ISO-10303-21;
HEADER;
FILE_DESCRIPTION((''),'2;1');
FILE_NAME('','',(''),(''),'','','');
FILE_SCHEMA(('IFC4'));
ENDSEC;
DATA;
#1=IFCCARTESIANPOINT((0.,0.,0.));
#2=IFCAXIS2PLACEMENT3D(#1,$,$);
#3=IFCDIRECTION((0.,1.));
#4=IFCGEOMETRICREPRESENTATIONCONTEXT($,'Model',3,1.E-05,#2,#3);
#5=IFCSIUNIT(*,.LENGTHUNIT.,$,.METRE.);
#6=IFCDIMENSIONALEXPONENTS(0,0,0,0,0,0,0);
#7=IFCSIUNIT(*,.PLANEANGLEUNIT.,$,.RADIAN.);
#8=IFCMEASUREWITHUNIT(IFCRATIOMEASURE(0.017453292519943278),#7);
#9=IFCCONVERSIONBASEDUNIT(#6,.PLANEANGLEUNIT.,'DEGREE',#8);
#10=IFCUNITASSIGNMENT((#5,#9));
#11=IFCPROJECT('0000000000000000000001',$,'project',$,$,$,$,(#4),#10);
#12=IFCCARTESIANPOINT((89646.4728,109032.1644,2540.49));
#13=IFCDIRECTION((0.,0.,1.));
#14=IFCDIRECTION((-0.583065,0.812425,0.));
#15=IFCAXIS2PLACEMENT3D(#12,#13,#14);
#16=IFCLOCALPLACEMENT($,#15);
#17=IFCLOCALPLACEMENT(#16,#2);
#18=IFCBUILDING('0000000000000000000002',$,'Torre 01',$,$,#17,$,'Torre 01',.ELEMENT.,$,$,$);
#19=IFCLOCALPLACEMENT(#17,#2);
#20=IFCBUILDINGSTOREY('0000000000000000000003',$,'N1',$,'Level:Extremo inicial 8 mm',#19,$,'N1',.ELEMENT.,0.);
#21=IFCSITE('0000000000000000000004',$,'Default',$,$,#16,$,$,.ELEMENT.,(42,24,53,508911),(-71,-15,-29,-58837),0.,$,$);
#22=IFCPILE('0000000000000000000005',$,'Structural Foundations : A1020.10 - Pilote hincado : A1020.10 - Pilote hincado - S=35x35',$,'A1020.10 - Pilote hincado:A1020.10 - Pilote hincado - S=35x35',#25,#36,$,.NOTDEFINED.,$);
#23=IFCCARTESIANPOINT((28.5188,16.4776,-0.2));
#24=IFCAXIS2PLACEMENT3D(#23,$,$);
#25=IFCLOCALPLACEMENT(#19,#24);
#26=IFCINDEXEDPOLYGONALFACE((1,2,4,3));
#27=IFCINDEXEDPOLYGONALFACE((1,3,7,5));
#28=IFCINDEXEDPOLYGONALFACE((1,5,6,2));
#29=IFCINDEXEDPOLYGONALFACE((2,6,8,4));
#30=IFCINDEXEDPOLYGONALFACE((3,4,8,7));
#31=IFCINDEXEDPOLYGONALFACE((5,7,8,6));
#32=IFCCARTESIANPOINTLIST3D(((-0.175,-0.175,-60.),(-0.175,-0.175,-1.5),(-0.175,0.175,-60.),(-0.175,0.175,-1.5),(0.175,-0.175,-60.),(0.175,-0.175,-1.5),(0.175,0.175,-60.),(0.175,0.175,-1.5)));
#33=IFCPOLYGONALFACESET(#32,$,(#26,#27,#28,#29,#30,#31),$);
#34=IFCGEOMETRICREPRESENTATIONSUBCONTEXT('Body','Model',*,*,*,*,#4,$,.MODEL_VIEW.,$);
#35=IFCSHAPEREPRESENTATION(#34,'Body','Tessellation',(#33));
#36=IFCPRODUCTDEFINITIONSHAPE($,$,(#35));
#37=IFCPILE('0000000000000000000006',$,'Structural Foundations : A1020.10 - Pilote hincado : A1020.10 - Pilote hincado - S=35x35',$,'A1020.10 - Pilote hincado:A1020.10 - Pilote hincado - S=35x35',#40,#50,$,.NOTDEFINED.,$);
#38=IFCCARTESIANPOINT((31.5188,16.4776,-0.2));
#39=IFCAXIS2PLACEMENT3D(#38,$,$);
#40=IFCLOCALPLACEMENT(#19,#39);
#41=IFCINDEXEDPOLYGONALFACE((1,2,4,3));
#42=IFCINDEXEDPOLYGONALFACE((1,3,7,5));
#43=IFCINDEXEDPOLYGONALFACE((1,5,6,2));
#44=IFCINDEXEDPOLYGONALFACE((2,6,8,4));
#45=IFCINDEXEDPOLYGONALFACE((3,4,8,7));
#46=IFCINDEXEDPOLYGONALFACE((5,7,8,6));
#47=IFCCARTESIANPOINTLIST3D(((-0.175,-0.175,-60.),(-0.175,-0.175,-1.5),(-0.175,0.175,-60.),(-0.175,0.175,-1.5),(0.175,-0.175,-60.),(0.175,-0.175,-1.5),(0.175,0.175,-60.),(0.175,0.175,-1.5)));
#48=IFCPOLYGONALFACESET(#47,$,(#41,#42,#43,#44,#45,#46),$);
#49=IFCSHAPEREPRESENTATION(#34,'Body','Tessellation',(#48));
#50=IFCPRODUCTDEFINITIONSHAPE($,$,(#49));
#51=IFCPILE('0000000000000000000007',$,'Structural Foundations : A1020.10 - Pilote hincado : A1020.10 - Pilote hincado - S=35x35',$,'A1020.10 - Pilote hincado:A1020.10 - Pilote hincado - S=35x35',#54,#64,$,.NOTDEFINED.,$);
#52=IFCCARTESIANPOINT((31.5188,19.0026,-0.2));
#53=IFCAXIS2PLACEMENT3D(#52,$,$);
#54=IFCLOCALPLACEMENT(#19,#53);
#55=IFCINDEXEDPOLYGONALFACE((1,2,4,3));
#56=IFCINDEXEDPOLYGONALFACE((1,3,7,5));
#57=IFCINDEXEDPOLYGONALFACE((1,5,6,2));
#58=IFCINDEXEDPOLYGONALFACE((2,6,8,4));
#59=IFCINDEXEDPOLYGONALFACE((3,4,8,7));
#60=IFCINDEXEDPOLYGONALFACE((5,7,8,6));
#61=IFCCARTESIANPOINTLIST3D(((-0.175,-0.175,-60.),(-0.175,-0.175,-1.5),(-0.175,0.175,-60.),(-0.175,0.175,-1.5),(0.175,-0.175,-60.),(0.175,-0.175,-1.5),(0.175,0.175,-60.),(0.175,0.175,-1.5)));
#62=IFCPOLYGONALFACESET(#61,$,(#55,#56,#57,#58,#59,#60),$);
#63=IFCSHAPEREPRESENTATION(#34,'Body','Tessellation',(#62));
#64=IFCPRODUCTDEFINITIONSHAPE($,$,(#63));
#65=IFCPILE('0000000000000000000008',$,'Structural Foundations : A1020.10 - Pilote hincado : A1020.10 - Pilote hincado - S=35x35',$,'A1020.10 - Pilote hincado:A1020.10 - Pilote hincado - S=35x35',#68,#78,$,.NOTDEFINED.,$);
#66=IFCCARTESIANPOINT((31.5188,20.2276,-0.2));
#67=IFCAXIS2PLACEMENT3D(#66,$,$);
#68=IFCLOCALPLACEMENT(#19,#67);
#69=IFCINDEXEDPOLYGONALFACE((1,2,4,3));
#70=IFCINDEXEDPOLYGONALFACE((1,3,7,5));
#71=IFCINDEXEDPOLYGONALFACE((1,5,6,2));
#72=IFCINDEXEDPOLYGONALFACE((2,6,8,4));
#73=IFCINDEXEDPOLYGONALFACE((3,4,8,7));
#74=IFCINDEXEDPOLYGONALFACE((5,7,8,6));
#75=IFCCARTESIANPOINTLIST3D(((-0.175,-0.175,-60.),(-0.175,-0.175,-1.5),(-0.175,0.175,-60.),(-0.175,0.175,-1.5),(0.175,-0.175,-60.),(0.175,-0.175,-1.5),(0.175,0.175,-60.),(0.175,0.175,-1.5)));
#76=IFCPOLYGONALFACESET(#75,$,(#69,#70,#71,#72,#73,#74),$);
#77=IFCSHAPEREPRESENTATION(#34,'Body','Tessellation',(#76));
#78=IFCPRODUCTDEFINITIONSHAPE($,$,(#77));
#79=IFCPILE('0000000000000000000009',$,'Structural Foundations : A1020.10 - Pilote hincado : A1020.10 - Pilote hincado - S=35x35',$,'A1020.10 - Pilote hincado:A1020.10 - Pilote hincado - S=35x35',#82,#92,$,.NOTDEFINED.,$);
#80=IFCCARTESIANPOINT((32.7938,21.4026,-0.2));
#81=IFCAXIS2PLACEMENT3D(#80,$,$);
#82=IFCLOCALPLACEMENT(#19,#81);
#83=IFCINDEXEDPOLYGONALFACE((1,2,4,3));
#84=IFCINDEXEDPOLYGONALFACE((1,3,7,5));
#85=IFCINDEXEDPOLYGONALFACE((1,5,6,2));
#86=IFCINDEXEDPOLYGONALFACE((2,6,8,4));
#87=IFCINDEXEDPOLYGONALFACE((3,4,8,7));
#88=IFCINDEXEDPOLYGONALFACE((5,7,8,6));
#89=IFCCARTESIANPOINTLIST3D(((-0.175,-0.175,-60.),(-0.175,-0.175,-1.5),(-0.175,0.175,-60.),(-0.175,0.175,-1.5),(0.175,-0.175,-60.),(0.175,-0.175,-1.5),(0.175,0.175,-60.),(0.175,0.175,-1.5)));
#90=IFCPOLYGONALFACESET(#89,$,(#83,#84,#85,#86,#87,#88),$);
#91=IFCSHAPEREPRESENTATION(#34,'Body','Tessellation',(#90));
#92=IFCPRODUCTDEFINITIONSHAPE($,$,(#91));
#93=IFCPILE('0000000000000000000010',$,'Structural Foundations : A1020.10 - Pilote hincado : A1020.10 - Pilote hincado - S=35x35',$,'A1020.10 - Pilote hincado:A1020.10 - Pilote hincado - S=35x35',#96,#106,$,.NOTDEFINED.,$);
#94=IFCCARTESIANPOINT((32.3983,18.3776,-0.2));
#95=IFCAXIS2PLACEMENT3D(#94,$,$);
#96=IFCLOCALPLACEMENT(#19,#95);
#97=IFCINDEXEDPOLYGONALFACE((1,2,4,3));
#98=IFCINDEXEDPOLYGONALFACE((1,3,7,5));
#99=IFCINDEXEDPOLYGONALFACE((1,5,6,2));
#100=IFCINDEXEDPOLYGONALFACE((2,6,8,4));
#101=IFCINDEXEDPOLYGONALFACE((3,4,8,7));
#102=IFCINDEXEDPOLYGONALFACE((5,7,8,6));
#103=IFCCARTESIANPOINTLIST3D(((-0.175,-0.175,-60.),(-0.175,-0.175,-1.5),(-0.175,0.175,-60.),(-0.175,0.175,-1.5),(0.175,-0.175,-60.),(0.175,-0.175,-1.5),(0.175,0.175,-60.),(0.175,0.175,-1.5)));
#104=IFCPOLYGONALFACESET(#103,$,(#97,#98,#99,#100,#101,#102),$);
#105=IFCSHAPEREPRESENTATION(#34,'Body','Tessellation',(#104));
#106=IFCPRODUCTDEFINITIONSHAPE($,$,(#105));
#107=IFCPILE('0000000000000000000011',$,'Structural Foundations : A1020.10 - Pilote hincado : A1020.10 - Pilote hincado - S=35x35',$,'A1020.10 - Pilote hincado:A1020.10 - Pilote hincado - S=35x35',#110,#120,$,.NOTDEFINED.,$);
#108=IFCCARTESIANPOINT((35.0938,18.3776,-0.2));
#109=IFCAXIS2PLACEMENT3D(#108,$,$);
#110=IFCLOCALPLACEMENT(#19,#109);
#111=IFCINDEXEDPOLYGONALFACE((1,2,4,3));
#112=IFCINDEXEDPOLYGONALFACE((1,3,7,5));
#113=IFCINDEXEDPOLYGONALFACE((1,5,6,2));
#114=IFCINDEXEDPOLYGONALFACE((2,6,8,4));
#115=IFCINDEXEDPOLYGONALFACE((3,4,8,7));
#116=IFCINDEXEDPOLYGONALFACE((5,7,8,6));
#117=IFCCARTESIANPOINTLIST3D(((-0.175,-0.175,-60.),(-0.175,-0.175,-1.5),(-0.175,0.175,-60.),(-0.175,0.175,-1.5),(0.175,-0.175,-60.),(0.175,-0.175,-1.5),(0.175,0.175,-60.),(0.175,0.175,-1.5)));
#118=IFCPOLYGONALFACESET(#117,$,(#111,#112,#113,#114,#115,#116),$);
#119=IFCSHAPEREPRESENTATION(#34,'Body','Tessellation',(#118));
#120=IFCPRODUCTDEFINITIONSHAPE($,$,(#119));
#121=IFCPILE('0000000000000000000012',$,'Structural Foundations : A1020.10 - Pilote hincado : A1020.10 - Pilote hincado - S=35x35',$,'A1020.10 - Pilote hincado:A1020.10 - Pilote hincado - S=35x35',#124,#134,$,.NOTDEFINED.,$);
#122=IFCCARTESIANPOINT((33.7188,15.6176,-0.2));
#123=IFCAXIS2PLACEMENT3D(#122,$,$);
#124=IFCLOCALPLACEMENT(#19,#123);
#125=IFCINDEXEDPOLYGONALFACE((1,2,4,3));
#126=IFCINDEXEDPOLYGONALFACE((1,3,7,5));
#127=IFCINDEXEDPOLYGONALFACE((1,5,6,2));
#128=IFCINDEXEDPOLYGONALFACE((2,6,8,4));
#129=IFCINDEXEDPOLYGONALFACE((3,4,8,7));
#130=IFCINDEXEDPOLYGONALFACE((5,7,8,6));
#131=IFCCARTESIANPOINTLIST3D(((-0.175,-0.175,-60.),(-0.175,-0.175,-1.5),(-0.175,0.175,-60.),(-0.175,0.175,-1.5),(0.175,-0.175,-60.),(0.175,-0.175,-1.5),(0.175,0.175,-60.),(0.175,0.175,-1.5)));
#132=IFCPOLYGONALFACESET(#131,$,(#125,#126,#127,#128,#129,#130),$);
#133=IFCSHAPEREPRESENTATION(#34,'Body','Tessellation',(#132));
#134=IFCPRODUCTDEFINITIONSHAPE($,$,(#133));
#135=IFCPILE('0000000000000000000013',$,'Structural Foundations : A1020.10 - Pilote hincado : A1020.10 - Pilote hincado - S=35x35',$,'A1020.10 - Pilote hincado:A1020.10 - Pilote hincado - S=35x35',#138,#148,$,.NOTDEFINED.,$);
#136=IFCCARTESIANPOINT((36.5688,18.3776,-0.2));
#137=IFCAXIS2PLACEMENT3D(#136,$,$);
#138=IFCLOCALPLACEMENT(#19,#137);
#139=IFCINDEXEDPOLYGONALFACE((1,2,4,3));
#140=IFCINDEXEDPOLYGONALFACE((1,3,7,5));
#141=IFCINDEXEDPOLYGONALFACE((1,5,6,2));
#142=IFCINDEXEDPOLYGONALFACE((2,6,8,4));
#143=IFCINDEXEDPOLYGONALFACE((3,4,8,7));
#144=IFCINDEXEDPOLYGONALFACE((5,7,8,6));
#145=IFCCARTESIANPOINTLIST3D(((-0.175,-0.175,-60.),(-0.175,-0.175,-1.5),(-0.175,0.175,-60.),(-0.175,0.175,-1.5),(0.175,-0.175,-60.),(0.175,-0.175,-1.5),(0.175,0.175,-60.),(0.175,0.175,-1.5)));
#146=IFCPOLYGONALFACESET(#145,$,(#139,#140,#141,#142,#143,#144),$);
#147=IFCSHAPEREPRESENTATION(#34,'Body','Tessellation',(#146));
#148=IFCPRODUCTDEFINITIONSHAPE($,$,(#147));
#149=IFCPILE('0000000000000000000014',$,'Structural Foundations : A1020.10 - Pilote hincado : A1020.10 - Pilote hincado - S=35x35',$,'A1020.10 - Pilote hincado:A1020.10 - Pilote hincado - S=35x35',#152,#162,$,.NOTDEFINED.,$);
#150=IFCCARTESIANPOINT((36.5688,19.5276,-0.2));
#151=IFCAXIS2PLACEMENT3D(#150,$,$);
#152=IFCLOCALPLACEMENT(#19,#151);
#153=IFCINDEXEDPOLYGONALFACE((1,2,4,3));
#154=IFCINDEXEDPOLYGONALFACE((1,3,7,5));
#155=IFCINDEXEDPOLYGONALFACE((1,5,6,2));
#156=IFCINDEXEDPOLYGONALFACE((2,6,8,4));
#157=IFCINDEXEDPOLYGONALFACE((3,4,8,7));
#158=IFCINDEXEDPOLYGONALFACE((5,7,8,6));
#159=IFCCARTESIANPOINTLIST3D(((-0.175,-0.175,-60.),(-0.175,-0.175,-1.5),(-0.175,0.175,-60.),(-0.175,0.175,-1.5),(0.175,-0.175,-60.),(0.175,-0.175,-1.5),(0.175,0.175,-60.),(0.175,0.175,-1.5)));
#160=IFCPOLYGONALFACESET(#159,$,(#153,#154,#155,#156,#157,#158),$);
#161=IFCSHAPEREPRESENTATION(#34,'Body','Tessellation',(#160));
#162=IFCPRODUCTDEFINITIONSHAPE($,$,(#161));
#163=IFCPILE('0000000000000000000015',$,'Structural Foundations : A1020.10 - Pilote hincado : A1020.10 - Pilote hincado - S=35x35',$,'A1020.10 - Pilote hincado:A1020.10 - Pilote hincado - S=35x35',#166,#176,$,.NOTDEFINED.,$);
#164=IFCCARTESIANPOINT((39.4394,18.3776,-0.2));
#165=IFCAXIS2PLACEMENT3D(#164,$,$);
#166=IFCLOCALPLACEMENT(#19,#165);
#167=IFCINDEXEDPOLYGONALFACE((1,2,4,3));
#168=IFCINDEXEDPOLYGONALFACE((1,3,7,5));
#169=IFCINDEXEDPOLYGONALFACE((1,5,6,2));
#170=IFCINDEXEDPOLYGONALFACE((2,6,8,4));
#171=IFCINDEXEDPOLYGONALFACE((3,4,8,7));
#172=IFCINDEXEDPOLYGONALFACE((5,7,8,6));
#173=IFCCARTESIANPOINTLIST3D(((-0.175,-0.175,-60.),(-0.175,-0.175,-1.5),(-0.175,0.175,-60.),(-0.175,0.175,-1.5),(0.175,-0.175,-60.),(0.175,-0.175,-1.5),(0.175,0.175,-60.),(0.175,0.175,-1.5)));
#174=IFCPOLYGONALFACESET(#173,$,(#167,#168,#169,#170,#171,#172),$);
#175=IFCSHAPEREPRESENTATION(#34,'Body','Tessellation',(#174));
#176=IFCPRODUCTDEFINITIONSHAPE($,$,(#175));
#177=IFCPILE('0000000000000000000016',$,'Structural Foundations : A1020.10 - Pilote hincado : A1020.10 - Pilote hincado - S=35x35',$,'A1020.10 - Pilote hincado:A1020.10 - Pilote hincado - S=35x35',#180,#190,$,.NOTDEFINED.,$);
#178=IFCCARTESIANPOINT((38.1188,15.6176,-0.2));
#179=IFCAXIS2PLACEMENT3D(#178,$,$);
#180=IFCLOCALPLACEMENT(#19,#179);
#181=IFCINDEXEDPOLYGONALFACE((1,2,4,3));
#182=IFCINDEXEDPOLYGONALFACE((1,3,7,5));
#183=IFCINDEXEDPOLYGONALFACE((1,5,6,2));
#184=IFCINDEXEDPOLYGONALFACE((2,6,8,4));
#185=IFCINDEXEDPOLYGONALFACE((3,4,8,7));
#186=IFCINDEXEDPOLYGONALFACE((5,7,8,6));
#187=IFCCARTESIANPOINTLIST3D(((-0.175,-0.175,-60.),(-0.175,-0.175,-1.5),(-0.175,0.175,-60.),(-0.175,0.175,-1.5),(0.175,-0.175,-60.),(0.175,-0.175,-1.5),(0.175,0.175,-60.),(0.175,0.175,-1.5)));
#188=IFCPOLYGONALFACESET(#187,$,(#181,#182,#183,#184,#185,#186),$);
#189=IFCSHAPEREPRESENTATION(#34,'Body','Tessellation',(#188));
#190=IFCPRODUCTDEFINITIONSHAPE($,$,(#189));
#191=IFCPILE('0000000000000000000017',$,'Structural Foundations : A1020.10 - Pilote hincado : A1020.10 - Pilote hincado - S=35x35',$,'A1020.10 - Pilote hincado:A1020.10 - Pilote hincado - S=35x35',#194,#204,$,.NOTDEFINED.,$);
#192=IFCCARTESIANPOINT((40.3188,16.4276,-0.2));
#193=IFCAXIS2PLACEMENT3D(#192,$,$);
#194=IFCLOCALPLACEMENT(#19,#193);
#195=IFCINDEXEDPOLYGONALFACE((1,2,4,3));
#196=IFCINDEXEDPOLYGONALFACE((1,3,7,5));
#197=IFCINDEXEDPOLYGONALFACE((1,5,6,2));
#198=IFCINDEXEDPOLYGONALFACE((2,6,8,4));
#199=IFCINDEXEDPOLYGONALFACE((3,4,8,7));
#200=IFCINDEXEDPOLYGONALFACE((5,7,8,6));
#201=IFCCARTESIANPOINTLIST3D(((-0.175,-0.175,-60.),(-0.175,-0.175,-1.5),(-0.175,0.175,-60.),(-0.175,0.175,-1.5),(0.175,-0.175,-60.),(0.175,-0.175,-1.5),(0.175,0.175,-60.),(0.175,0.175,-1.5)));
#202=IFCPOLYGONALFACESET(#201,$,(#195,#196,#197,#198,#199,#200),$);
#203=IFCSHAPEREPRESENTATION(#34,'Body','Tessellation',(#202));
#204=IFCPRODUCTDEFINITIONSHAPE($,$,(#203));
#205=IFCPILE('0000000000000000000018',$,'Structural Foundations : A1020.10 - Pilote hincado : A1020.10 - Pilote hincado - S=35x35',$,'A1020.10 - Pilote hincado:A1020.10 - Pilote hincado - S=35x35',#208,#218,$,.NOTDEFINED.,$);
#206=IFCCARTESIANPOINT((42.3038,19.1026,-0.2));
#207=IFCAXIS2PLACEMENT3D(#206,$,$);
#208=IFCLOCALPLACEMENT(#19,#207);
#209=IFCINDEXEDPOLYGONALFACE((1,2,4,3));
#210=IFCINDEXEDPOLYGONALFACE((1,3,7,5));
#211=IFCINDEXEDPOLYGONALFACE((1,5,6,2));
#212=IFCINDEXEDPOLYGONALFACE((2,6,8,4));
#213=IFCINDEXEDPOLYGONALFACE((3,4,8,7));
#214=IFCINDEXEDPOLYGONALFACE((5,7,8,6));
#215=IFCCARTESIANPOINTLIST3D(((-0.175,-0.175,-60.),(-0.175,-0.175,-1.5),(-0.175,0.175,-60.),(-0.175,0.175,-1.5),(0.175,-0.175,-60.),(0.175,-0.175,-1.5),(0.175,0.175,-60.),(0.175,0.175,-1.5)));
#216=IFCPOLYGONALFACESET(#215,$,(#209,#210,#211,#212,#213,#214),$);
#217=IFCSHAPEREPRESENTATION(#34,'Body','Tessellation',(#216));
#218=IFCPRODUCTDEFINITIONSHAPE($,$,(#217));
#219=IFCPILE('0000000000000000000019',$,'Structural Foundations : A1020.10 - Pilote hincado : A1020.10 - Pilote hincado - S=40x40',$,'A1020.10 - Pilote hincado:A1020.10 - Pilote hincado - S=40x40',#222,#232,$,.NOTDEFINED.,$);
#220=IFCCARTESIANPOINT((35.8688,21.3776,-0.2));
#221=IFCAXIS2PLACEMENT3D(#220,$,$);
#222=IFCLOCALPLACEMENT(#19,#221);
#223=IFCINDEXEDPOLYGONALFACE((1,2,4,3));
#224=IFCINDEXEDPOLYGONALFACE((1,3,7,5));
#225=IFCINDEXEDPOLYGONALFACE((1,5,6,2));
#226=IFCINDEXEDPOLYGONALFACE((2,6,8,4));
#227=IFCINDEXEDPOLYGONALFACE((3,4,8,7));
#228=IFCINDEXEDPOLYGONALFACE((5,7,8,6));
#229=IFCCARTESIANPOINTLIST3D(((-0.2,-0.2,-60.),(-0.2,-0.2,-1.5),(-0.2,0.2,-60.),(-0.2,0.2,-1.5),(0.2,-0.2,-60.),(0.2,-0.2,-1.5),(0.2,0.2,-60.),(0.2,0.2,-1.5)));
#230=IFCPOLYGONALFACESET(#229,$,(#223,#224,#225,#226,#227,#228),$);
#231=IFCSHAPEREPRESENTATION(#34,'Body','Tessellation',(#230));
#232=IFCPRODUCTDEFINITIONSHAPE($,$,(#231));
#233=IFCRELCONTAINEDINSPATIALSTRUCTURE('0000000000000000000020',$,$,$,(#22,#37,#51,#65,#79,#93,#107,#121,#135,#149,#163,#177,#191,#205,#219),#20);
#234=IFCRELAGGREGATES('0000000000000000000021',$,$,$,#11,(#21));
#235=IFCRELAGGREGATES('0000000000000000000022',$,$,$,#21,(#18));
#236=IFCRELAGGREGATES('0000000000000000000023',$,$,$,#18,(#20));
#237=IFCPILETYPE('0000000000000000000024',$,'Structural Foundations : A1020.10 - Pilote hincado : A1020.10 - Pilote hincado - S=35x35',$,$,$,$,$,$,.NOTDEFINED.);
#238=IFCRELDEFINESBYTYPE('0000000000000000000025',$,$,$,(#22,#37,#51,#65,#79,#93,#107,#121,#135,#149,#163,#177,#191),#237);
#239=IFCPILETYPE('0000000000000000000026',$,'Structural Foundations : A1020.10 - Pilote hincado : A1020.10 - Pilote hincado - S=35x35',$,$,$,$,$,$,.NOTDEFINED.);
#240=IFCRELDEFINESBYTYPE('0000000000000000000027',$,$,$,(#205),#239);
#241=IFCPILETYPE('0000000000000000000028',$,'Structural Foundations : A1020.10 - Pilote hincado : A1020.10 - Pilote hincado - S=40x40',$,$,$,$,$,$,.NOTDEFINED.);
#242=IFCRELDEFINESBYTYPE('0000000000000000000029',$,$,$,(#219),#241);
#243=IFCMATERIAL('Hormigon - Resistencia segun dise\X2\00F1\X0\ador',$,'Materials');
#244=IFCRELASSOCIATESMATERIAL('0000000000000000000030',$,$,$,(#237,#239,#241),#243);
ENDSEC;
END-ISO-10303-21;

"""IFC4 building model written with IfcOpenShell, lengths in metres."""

from ifc_helpers import new_model, entity, si_unit, converted_unit, direction, frame, origin, origin_2d_with_axis, place, context, subcontext, project, spatial, polyline, segment, composite_curve, rectangle, outline, extrude, source, transform, mapped, material, material_profile, profile_set, type_object, type_shapes, element, save


model = new_model("IFC4")

# Units and contexts
model_context = context("Model", 3, precision=1e-05, world=origin(), true_north=direction((0.0, 1.0)))
body_context = subcontext(model_context, "Body", "Model", "MODEL_VIEW")
ifc_project = project(units=[si_unit("LENGTHUNIT", "METRE"), converted_unit("PLANEANGLEUNIT", "DEGREE", entity("IfcRatioMeasure", 0.017453292519943278), si_unit("PLANEANGLEUNIT", "RADIAN"), dimensions=[0, 0, 0, 0, 0, 0, 0])], contexts=[model_context])

# Site, building, storey
site_placement = place(None, frame((89646.4728, 109032.1644, 2540.49), z_axis=(0.0, 0.0, 1.0), x_axis=(-0.583065, 0.812425, 0.0)))
site = spatial("IfcSite", under=ifc_project, at=site_placement, Name="Default", CompositionType="ELEMENT", RefLatitude=(42, 24, 53, 508911), RefLongitude=(-71, -15, -29, -58837), RefElevation=0.0)
building_placement = place(site_placement, origin())
building = spatial("IfcBuilding", under=site, at=building_placement, Name="Torre 01", LongName="Torre 01", CompositionType="ELEMENT")
storey_placement = place(building_placement, origin())
storey = spatial("IfcBuildingStorey", under=building, at=storey_placement, Name="N1", ObjectType="Level:Extremo inicial 8 mm", LongName="N1", CompositionType="ELEMENT", Elevation=0.0)

# Piles
ifc_material_1 = material(Name="Hormigon - Resistencia segun diseñador", Category="Materials")
ifc_material_profile_1 = material_profile(ifc_material_1, outline(composite_curve([segment(polyline([(0.175, -0.175, -60.0), (-0.175, -0.175, -60.0)]), True, "CONTINUOUS"), segment(polyline([(-0.175, -0.175, -60.0), (-0.175, 0.175, -60.0)]), True, "CONTINUOUS"), segment(polyline([(-0.175, 0.175, -60.0), (0.175, 0.175, -60.0)]), True, "CONTINUOUS"), segment(polyline([(0.175, 0.175, -60.0), (0.175, -0.175, -60.0)]), True, "CONTINUOUS")], self_intersect=False), kind="CURVE"), Name="A1020.10 - Pilote hincado - S=35x35")
ifc_profile_set_1 = profile_set([ifc_material_profile_1], Name="A1020.10 - Pilote hincado - S=35x35")
pile_type_1 = type_object("IfcPileType", Name="Structural Foundations : A1020.10 - Pilote hincado : A1020.10 - Pilote hincado - S=35x35", PredefinedType="NOTDEFINED", material=ifc_profile_set_1)
shared_shape_1 = source(origin(), body_context, "Body", "SweptSolid", [
    extrude(rectangle(XDim=0.35, YDim=0.35, at=origin_2d_with_axis()), frame((0.0, 0.0, -60.0), z_axis=(0.0, 0.0, 1.0), x_axis=(0.0, -1.0, 0.0)), (0.0, 0.0, 1.0), 58.5),
])
type_shapes(pile_type_1, [shared_shape_1])
for number, where, name in (
    (1, (28.5188, 16.4776, -0.2), "Structural Foundations : A1020.10 - Pilote hincado : A1020.10 - Pilote hincado - S=35x35"),
    (2, (31.5188, 16.4776, -0.2), "Structural Foundations : A1020.10 - Pilote hincado : A1020.10 - Pilote hincado - S=35x35"),
    (3, (31.5188, 19.0026, -0.2), "Structural Foundations : A1020.10 - Pilote hincado : A1020.10 - Pilote hincado - S=35x35"),
    (4, (31.5188, 20.2276, -0.2), "Structural Foundations : A1020.10 - Pilote hincado : A1020.10 - Pilote hincado - S=35x35"),
    (5, (32.7938, 21.4026, -0.2), "Structural Foundations : A1020.10 - Pilote hincado : A1020.10 - Pilote hincado - S=35x35"),
    (6, (32.3983, 18.3776, -0.2), "Structural Foundations : A1020.10 - Pilote hincado : A1020.10 - Pilote hincado - S=35x35"),
    (7, (35.0938, 18.3776, -0.2), "Structural Foundations : A1020.10 - Pilote hincado : A1020.10 - Pilote hincado - S=35x35"),
    (8, (33.7188, 15.6176, -0.2), "Structural Foundations : A1020.10 - Pilote hincado : A1020.10 - Pilote hincado - S=35x35"),
    (9, (36.5688, 18.3776, -0.2), "Structural Foundations : A1020.10 - Pilote hincado : A1020.10 - Pilote hincado - S=35x35"),
    (10, (36.5688, 19.5276, -0.2), "Structural Foundations : A1020.10 - Pilote hincado : A1020.10 - Pilote hincado - S=35x35"),
    (11, (39.4394, 18.3776, -0.2), "Structural Foundations : A1020.10 - Pilote hincado : A1020.10 - Pilote hincado - S=35x35"),
    (12, (38.1188, 15.6176, -0.2), "Structural Foundations : A1020.10 - Pilote hincado : A1020.10 - Pilote hincado - S=35x35"),
    (13, (40.3188, 16.4276, -0.2), "Structural Foundations : A1020.10 - Pilote hincado : A1020.10 - Pilote hincado - S=35x35"),
):
    element("IfcPile", number, at=place(storey_placement, frame(where)), inside=storey, type_object=pile_type_1, Name=name, ObjectType="A1020.10 - Pilote hincado:A1020.10 - Pilote hincado - S=35x35", PredefinedType="NOTDEFINED", context=body_context, shape_type="MappedRepresentation", body=[
        mapped(shared_shape_1, transform((0.0, 0.0, 0.0), scale=1.0)),
    ])
pile_type_2 = type_object("IfcPileType", Name="Structural Foundations : A1020.10 - Pilote hincado : A1020.10 - Pilote hincado - S=35x35", PredefinedType="NOTDEFINED", material=ifc_profile_set_1)
shared_shape_2 = source(origin(), body_context, "Body", "SweptSolid", [
    extrude(rectangle(XDim=0.35, YDim=0.35, at=origin_2d_with_axis()), frame((0.0, 0.0, -60.0), z_axis=(0.0, 0.0, 1.0), x_axis=(0.0, -1.0, 0.0)), (0.0, 0.0, 1.0), 58.5),
])
type_shapes(pile_type_2, [shared_shape_2])
pile_placement = place(storey_placement, frame((42.3038, 19.1026, -0.2)))
element("IfcPile", 14, at=pile_placement, inside=storey, type_object=pile_type_2, Name="Structural Foundations : A1020.10 - Pilote hincado : A1020.10 - Pilote hincado - S=35x35", ObjectType="A1020.10 - Pilote hincado:A1020.10 - Pilote hincado - S=35x35", PredefinedType="NOTDEFINED", context=body_context, shape_type="MappedRepresentation", body=[
    mapped(shared_shape_2, transform((0.0, 0.0, 0.0), scale=1.0)),
])
ifc_material_profile_2 = material_profile(ifc_material_1, outline(composite_curve([segment(polyline([(0.2, -0.2, -60.0), (-0.2, -0.2, -60.0)]), True, "CONTINUOUS"), segment(polyline([(-0.2, -0.2, -60.0), (-0.2, 0.2, -60.0)]), True, "CONTINUOUS"), segment(polyline([(-0.2, 0.2, -60.0), (0.2, 0.2, -60.0)]), True, "CONTINUOUS"), segment(polyline([(0.2, 0.2, -60.0), (0.2, -0.2, -60.0)]), True, "CONTINUOUS")], self_intersect=False), kind="CURVE"), Name="A1020.10 - Pilote hincado - S=40x40")
ifc_profile_set_2 = profile_set([ifc_material_profile_2], Name="A1020.10 - Pilote hincado - S=40x40")
pile_type_3 = type_object("IfcPileType", Name="Structural Foundations : A1020.10 - Pilote hincado : A1020.10 - Pilote hincado - S=40x40", PredefinedType="NOTDEFINED", material=ifc_profile_set_2)
shared_shape_3 = source(origin(), body_context, "Body", "SweptSolid", [
    extrude(rectangle(XDim=0.4, YDim=0.4, at=origin_2d_with_axis()), frame((0.0, 0.0, -60.0), z_axis=(0.0, 0.0, 1.0), x_axis=(0.0, -1.0, 0.0)), (0.0, 0.0, 1.0), 58.5),
])
type_shapes(pile_type_3, [shared_shape_3])
for number, where, name in (
    (15, (35.8688, 21.3776, -0.2), "Structural Foundations : A1020.10 - Pilote hincado : A1020.10 - Pilote hincado - S=40x40"),
):
    element("IfcPile", number, at=place(storey_placement, frame(where)), inside=storey, type_object=pile_type_3, Name=name, ObjectType="A1020.10 - Pilote hincado:A1020.10 - Pilote hincado - S=40x40", PredefinedType="NOTDEFINED", context=body_context, shape_type="MappedRepresentation", body=[
        mapped(shared_shape_3, transform((0.0, 0.0, 0.0), scale=1.0)),
    ])

save(model, "model.ifc")
